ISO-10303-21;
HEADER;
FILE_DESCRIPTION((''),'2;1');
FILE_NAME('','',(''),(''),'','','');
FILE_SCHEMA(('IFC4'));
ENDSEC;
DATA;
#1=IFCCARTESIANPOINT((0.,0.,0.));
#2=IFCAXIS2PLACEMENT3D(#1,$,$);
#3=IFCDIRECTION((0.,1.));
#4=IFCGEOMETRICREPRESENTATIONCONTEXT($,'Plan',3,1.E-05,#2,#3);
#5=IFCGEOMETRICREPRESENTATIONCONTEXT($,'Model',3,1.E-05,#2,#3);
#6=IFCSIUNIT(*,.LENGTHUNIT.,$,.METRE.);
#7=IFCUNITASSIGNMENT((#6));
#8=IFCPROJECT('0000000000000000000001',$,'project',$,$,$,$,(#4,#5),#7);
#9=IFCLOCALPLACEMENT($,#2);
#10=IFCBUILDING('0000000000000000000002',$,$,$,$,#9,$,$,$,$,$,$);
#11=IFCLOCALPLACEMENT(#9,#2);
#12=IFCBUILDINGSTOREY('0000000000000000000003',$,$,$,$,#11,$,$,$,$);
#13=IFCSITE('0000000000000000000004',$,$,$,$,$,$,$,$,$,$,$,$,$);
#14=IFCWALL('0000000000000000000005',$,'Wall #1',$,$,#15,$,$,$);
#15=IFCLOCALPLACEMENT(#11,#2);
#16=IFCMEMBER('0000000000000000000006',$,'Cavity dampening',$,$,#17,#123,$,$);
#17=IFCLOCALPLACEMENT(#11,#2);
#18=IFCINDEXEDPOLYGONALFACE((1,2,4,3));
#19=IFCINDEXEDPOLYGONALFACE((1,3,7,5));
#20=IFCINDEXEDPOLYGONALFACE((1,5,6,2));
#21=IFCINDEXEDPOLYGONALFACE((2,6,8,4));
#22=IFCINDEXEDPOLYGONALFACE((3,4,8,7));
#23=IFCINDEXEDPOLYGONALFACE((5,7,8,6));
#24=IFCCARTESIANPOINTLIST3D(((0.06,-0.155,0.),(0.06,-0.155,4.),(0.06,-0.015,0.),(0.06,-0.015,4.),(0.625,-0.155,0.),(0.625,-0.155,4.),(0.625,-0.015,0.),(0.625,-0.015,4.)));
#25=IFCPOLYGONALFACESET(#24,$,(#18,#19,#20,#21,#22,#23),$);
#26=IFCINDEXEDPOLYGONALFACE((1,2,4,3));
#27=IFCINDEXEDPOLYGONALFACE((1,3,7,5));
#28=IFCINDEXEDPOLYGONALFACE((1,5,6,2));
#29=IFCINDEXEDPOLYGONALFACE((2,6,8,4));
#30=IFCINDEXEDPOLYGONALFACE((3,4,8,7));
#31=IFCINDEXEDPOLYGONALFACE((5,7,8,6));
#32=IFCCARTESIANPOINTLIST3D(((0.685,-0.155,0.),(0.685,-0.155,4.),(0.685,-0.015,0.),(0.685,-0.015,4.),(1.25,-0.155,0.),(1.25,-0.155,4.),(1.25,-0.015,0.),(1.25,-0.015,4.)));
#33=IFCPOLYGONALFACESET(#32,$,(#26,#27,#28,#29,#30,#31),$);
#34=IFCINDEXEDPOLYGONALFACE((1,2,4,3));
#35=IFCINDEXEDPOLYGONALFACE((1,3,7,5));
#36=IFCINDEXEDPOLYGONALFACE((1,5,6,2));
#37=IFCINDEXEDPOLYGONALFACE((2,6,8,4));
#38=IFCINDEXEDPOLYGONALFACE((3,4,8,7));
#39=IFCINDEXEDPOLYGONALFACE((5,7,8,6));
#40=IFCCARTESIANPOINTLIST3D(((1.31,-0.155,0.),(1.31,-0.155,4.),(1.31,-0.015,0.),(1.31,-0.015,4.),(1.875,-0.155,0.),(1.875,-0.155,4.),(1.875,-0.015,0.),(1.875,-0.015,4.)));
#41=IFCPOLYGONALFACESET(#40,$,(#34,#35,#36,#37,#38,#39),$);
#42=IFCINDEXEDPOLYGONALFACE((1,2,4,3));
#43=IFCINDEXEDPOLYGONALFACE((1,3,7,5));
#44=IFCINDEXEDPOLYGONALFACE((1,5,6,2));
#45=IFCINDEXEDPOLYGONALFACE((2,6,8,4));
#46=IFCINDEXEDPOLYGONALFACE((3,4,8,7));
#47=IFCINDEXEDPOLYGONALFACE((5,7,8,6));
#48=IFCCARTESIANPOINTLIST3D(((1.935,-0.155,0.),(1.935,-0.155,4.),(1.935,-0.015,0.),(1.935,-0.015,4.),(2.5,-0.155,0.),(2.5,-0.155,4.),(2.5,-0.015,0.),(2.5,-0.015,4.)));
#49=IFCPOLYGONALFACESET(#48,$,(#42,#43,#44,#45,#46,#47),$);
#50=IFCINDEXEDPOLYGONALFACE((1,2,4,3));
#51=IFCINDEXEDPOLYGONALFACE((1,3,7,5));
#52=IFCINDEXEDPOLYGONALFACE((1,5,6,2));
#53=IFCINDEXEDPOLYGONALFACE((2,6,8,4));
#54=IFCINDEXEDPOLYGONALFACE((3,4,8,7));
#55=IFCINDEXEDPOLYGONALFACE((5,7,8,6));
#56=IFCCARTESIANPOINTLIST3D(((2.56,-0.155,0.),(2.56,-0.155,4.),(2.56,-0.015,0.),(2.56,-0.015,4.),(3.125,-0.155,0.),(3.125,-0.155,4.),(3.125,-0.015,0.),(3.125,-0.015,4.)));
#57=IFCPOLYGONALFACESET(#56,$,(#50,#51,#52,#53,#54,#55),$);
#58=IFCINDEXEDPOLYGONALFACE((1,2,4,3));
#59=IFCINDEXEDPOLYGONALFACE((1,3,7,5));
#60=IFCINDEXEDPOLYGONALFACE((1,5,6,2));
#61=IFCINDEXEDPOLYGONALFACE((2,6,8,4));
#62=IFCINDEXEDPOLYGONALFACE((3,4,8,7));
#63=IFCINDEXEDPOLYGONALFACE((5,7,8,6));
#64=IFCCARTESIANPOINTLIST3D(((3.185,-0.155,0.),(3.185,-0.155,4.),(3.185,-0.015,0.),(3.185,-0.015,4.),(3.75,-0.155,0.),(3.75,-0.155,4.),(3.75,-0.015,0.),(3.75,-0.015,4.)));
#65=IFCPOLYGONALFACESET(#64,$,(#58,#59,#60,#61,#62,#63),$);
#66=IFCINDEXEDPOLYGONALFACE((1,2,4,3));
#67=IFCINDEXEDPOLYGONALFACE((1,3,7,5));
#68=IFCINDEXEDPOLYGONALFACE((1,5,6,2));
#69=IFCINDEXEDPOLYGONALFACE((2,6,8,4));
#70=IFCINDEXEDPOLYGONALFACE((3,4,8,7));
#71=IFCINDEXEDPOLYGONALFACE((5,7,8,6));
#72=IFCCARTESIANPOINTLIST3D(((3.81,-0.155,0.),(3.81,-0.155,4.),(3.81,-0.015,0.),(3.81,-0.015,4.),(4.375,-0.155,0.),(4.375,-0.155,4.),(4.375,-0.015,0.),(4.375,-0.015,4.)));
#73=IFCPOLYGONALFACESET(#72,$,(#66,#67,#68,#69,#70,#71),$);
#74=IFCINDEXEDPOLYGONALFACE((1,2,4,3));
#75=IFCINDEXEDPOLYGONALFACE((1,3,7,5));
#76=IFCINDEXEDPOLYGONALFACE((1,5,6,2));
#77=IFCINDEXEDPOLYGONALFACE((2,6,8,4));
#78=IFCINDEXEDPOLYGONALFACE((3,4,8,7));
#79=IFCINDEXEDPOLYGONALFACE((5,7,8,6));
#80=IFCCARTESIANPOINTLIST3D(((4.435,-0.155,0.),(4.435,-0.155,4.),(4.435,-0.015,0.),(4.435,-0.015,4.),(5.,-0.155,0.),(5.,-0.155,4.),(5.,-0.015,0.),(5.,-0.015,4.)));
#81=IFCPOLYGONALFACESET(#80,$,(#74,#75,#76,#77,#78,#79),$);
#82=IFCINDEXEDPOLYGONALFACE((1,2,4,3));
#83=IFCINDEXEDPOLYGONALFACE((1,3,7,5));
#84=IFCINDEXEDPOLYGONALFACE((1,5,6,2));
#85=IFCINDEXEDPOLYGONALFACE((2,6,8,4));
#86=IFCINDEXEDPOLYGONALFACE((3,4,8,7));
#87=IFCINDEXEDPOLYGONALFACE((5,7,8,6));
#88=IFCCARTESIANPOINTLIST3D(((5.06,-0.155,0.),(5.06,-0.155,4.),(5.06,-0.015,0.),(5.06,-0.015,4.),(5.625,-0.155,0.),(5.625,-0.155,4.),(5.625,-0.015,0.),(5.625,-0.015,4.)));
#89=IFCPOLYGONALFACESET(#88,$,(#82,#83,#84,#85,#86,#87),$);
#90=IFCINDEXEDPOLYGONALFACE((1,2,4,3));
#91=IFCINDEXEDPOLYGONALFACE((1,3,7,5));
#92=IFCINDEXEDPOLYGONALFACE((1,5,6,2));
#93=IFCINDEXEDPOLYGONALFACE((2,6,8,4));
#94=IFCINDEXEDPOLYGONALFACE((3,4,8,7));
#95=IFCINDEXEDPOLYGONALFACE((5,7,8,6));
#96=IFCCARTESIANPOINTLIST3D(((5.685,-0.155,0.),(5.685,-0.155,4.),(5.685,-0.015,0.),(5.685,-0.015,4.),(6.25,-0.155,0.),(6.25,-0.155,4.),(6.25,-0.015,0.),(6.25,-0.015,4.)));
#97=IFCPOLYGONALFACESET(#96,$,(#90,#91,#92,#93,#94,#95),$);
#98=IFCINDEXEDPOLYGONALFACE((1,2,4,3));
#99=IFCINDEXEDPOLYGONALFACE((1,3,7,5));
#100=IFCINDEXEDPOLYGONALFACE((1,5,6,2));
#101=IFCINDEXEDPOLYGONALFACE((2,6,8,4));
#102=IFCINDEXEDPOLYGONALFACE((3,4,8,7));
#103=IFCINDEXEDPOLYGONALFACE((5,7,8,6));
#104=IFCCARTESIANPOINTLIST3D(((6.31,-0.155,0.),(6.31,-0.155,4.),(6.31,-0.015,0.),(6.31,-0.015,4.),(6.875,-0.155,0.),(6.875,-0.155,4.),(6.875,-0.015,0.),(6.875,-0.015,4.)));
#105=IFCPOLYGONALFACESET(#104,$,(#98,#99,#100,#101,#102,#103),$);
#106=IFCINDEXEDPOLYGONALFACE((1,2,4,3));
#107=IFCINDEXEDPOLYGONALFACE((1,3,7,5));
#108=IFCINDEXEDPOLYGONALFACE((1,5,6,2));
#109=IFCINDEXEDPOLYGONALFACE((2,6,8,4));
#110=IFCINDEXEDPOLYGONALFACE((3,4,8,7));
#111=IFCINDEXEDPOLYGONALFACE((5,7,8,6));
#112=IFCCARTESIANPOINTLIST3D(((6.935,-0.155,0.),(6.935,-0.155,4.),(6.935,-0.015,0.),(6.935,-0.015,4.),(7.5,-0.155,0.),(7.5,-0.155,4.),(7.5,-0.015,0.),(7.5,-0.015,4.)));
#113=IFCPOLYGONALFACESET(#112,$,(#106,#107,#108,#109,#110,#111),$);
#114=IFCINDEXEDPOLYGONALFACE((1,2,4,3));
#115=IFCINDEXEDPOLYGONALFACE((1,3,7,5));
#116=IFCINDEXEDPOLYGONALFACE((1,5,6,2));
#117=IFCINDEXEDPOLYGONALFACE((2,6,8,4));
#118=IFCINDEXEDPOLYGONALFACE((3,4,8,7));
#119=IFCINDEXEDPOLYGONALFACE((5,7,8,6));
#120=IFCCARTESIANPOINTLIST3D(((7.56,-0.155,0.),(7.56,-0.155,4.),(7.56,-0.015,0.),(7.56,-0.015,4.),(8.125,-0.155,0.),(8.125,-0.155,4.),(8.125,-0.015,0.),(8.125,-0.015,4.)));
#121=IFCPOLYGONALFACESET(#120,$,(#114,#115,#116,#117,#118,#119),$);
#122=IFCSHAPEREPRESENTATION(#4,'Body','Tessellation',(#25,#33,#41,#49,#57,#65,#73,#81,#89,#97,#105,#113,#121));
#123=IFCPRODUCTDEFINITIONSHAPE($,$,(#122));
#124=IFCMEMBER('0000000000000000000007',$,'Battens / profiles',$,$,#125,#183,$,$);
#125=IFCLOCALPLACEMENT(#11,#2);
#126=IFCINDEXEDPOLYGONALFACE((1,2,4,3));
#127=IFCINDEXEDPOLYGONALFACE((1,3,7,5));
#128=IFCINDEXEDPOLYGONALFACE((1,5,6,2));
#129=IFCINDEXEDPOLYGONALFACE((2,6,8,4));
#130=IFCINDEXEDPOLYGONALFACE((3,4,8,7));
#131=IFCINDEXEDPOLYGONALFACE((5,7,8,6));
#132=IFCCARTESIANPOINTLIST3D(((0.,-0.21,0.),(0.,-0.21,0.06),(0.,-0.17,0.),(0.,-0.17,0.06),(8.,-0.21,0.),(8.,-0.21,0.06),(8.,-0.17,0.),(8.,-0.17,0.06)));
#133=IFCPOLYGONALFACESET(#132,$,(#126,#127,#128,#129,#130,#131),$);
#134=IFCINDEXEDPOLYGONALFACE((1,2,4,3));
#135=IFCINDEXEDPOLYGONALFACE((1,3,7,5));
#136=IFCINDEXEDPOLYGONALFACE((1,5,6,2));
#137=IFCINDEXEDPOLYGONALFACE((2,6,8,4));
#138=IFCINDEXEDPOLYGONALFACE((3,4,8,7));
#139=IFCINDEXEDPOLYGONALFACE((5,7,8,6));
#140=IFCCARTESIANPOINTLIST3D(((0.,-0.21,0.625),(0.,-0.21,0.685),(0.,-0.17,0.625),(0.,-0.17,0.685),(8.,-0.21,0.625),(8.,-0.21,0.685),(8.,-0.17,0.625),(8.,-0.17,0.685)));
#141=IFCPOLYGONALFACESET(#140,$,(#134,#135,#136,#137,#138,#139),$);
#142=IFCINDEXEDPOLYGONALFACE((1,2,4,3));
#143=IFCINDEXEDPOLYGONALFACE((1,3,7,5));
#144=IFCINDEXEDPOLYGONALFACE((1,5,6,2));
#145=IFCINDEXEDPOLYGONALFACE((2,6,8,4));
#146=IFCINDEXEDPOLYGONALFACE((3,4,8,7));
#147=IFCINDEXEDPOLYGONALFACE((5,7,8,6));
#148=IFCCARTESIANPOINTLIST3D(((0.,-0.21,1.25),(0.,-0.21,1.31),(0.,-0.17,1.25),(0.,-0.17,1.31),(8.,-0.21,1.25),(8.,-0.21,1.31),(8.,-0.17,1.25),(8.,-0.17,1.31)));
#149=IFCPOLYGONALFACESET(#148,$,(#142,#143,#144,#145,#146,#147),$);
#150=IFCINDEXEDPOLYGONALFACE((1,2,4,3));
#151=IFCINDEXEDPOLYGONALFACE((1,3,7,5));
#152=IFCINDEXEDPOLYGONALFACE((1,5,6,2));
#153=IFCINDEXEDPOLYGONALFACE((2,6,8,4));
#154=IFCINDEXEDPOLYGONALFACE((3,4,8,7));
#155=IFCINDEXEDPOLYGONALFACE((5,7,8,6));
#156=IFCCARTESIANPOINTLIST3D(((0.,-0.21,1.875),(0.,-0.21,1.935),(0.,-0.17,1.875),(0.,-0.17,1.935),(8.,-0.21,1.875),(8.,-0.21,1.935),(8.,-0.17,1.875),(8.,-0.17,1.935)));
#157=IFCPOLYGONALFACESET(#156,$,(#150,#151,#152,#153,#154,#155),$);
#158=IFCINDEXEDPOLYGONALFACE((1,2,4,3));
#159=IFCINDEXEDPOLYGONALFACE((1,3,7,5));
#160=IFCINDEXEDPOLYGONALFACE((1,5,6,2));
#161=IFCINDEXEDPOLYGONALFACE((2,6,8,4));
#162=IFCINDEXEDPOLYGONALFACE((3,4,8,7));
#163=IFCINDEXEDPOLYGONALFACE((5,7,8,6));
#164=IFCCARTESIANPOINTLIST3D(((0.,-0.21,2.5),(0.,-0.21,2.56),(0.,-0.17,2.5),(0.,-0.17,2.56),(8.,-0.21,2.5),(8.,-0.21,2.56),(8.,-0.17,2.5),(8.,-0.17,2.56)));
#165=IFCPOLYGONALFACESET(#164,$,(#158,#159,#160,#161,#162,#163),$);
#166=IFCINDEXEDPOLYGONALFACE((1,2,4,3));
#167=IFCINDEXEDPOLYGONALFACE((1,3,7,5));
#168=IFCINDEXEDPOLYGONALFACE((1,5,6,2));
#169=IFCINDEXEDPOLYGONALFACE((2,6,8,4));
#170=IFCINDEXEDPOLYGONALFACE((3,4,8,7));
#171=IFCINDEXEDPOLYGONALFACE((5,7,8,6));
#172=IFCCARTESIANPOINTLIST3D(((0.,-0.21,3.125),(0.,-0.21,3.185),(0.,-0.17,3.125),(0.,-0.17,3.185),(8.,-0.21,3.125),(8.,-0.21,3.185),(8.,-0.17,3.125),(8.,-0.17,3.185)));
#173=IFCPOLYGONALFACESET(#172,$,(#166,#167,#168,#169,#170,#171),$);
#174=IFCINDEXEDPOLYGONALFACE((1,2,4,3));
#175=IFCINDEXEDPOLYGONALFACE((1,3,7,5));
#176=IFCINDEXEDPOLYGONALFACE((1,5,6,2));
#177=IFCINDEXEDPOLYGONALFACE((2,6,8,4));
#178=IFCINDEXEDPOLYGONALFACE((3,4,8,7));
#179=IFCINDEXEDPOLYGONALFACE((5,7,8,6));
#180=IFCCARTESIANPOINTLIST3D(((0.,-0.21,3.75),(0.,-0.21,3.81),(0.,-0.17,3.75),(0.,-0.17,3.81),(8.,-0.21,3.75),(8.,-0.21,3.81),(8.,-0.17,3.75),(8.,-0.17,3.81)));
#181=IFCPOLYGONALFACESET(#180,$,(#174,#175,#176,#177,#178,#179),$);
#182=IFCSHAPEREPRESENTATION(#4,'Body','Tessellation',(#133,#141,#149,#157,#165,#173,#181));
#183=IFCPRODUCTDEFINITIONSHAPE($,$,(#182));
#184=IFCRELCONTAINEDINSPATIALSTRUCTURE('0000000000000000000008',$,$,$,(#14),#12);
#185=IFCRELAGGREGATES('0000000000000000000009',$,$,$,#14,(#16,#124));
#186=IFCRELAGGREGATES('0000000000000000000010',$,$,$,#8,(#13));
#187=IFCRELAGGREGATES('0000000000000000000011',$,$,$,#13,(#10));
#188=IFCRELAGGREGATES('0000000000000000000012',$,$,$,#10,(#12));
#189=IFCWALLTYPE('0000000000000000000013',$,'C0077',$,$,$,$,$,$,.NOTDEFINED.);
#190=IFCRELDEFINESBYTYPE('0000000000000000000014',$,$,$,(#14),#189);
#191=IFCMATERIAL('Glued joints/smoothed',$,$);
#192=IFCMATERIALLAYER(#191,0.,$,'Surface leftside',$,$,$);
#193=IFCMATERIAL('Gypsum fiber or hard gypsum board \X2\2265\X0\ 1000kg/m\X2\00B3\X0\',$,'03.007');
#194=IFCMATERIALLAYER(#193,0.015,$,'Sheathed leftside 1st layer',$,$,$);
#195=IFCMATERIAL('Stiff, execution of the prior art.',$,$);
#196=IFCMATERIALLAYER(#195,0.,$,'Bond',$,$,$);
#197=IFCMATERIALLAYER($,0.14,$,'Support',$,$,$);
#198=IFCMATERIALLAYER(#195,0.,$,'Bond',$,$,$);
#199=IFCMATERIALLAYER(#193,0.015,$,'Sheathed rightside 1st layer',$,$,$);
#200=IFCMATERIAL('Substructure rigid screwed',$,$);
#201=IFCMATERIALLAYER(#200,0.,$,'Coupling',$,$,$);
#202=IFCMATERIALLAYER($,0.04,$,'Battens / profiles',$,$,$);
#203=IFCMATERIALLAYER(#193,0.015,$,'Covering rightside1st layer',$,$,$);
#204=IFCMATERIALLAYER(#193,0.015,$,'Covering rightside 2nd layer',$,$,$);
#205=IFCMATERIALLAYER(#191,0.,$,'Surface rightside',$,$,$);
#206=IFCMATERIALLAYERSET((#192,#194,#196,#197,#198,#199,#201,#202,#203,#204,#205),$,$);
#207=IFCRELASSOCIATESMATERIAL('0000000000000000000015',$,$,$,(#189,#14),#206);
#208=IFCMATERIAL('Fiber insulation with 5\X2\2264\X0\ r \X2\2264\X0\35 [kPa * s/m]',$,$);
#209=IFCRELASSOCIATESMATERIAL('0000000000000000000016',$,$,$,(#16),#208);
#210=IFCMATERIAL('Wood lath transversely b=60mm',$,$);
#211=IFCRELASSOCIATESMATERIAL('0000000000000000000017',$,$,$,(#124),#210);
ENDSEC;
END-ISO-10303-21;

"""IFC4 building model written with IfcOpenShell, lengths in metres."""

from ifc_helpers import new_model, si_unit, direction, frame, frame_2d, origin, place, context, project, spatial, rectangle, extrude, material, layer, layer_set, type_object, element, aggregate, save


model = new_model("IFC4")

# Units and contexts
plan_context = context("Plan", 3, precision=1e-05, world=origin(), true_north=direction((0.0, 1.0)))
model_context = context("Model", 3, precision=1e-05, world=origin(), true_north=direction((0.0, 1.0)))
ifc_project = project(units=[si_unit("LENGTHUNIT", "METRE")], contexts=[plan_context, model_context])

# Site, building, storey
site = spatial("IfcSite", under=ifc_project)
building_placement = place(None, origin())
building = spatial("IfcBuilding", under=site, at=building_placement)
storey_placement = place(building_placement, origin())
storey = spatial("IfcBuildingStorey", under=building, at=storey_placement)

# Wall, members
ifc_material_1 = material(Name="Glued joints/smoothed")
ifc_layer_1 = layer(ifc_material_1, 0.0, Name="Surface leftside")
ifc_material_2 = material(Name="Gypsum fiber or hard gypsum board ≥ 1000kg/m³", Category="03.007")
ifc_layer_2 = layer(ifc_material_2, 0.015, Name="Sheathed leftside 1st layer")
ifc_material_3 = material(Name="Stiff, execution of the prior art.")
ifc_layer_3 = layer(ifc_material_3, 0.0, Name="Bond")
ifc_layer_4 = layer(None, 0.14, Name="Support")
ifc_layer_5 = layer(ifc_material_3, 0.0, Name="Bond")
ifc_layer_6 = layer(ifc_material_2, 0.015, Name="Sheathed rightside 1st layer")
ifc_material_4 = material(Name="Substructure rigid screwed")
ifc_layer_7 = layer(ifc_material_4, 0.0, Name="Coupling")
ifc_layer_8 = layer(None, 0.04, Name="Battens / profiles")
ifc_layer_9 = layer(ifc_material_2, 0.015, Name="Covering rightside1st layer")
ifc_layer_10 = layer(ifc_material_2, 0.015, Name="Covering rightside 2nd layer")
ifc_layer_11 = layer(ifc_material_1, 0.0, Name="Surface rightside")
ifc_layer_set = layer_set([ifc_layer_1, ifc_layer_2, ifc_layer_3, ifc_layer_4, ifc_layer_5, ifc_layer_6, ifc_layer_7, ifc_layer_8, ifc_layer_9, ifc_layer_10, ifc_layer_11])
wall_type = type_object("IfcWallType", Name="C0077", PredefinedType="NOTDEFINED", material=ifc_layer_set)
wall_placement = place(None, frame((0.0, 0.0, 0.0), z_axis=(0.0, -1.0, 0.0), x_axis=(1.0, 0.0, 0.0)))
wall = element("IfcWall", 1, at=wall_placement, inside=storey, type_object=wall_type, material=ifc_layer_set, Name="Wall #1")
ifc_material_5 = material(Name="Fiber insulation with 5≤ r ≤35 [kPa * s/m]")
member_1_placement = place(wall_placement, origin())
member_1 = element("IfcMember", 2, at=member_1_placement, material=ifc_material_5, Name="Cavity dampening", context=plan_context, shape_type="SweptSolid", body=[
    extrude(rectangle(XDim=0.565, YDim=0.14, at=frame_2d((0.2825, 0.07), x_axis=(1.0, 0.0))), frame((0.06, 4.0, 0.015), z_axis=(0.0, -1.0, 0.0), x_axis=(1.0, 0.0, 0.0)), (0.0, 0.0, 1.0), 4.0),
    extrude(rectangle(XDim=0.565, YDim=0.14, at=frame_2d((0.2825, 0.07), x_axis=(1.0, 0.0))), frame((0.685, 4.0, 0.015), z_axis=(0.0, -1.0, 0.0), x_axis=(1.0, 0.0, 0.0)), (0.0, 0.0, 1.0), 4.0),
    extrude(rectangle(XDim=0.565, YDim=0.14, at=frame_2d((0.2825, 0.07), x_axis=(1.0, 0.0))), frame((1.31, 4.0, 0.015), z_axis=(0.0, -1.0, 0.0), x_axis=(1.0, 0.0, 0.0)), (0.0, 0.0, 1.0), 4.0),
    extrude(rectangle(XDim=0.565, YDim=0.14, at=frame_2d((0.2825, 0.07), x_axis=(1.0, 0.0))), frame((1.935, 4.0, 0.015), z_axis=(0.0, -1.0, 0.0), x_axis=(1.0, 0.0, 0.0)), (0.0, 0.0, 1.0), 4.0),
    extrude(rectangle(XDim=0.565, YDim=0.14, at=frame_2d((0.2825, 0.07), x_axis=(1.0, 0.0))), frame((2.56, 4.0, 0.015), z_axis=(0.0, -1.0, 0.0), x_axis=(1.0, 0.0, 0.0)), (0.0, 0.0, 1.0), 4.0),
    extrude(rectangle(XDim=0.565, YDim=0.14, at=frame_2d((0.2825, 0.07), x_axis=(1.0, 0.0))), frame((3.185, 4.0, 0.015), z_axis=(0.0, -1.0, 0.0), x_axis=(1.0, 0.0, 0.0)), (0.0, 0.0, 1.0), 4.0),
    extrude(rectangle(XDim=0.565, YDim=0.14, at=frame_2d((0.2825, 0.07), x_axis=(1.0, 0.0))), frame((3.81, 4.0, 0.015), z_axis=(0.0, -1.0, 0.0), x_axis=(1.0, 0.0, 0.0)), (0.0, 0.0, 1.0), 4.0),
    extrude(rectangle(XDim=0.565, YDim=0.14, at=frame_2d((0.2825, 0.07), x_axis=(1.0, 0.0))), frame((4.435, 4.0, 0.015), z_axis=(0.0, -1.0, 0.0), x_axis=(1.0, 0.0, 0.0)), (0.0, 0.0, 1.0), 4.0),
    extrude(rectangle(XDim=0.565, YDim=0.14, at=frame_2d((0.2825, 0.07), x_axis=(1.0, 0.0))), frame((5.06, 4.0, 0.015), z_axis=(0.0, -1.0, 0.0), x_axis=(1.0, 0.0, 0.0)), (0.0, 0.0, 1.0), 4.0),
    extrude(rectangle(XDim=0.565, YDim=0.14, at=frame_2d((0.2825, 0.07), x_axis=(1.0, 0.0))), frame((5.685, 4.0, 0.015), z_axis=(0.0, -1.0, 0.0), x_axis=(1.0, 0.0, 0.0)), (0.0, 0.0, 1.0), 4.0),
    extrude(rectangle(XDim=0.565, YDim=0.14, at=frame_2d((0.2825, 0.07), x_axis=(1.0, 0.0))), frame((6.31, 4.0, 0.015), z_axis=(0.0, -1.0, 0.0), x_axis=(1.0, 0.0, 0.0)), (0.0, 0.0, 1.0), 4.0),
    extrude(rectangle(XDim=0.565, YDim=0.14, at=frame_2d((0.2825, 0.07), x_axis=(1.0, 0.0))), frame((6.935, 4.0, 0.015), z_axis=(0.0, -1.0, 0.0), x_axis=(1.0, 0.0, 0.0)), (0.0, 0.0, 1.0), 4.0),
    extrude(rectangle(XDim=0.565, YDim=0.14, at=frame_2d((0.2825, 0.07), x_axis=(1.0, 0.0))), frame((7.56, 4.0, 0.015), z_axis=(0.0, -1.0, 0.0), x_axis=(1.0, 0.0, 0.0)), (0.0, 0.0, 1.0), 4.0),
])
ifc_material_6 = material(Name="Wood lath transversely b=60mm")
member_2_placement = place(wall_placement, origin())
member_2 = element("IfcMember", 3, at=member_2_placement, material=ifc_material_6, Name="Battens / profiles", context=plan_context, shape_type="SweptSolid", body=[
    extrude(rectangle(XDim=0.06, YDim=0.04, at=frame_2d((0.03, 0.02), x_axis=(1.0, 0.0))), frame((0.0, 0.0, 0.17), z_axis=(1.0, 0.0, 0.0), x_axis=(0.0, 1.0, 0.0)), (0.0, 0.0, 1.0), 8.0),
    extrude(rectangle(XDim=0.06, YDim=0.04, at=frame_2d((0.03, 0.02), x_axis=(1.0, 0.0))), frame((0.0, 0.625, 0.17), z_axis=(1.0, 0.0, 0.0), x_axis=(0.0, 1.0, 0.0)), (0.0, 0.0, 1.0), 8.0),
    extrude(rectangle(XDim=0.06, YDim=0.04, at=frame_2d((0.03, 0.02), x_axis=(1.0, 0.0))), frame((0.0, 1.25, 0.17), z_axis=(1.0, 0.0, 0.0), x_axis=(0.0, 1.0, 0.0)), (0.0, 0.0, 1.0), 8.0),
    extrude(rectangle(XDim=0.06, YDim=0.04, at=frame_2d((0.03, 0.02), x_axis=(1.0, 0.0))), frame((0.0, 1.875, 0.17), z_axis=(1.0, 0.0, 0.0), x_axis=(0.0, 1.0, 0.0)), (0.0, 0.0, 1.0), 8.0),
    extrude(rectangle(XDim=0.06, YDim=0.04, at=frame_2d((0.03, 0.02), x_axis=(1.0, 0.0))), frame((0.0, 2.5, 0.17), z_axis=(1.0, 0.0, 0.0), x_axis=(0.0, 1.0, 0.0)), (0.0, 0.0, 1.0), 8.0),
    extrude(rectangle(XDim=0.06, YDim=0.04, at=frame_2d((0.03, 0.02), x_axis=(1.0, 0.0))), frame((0.0, 3.125, 0.17), z_axis=(1.0, 0.0, 0.0), x_axis=(0.0, 1.0, 0.0)), (0.0, 0.0, 1.0), 8.0),
    extrude(rectangle(XDim=0.06, YDim=0.04, at=frame_2d((0.03, 0.02), x_axis=(1.0, 0.0))), frame((0.0, 3.75, 0.17), z_axis=(1.0, 0.0, 0.0), x_axis=(0.0, 1.0, 0.0)), (0.0, 0.0, 1.0), 8.0),
])
aggregate(wall, [member_1, member_2])

save(model, "model.ifc")
